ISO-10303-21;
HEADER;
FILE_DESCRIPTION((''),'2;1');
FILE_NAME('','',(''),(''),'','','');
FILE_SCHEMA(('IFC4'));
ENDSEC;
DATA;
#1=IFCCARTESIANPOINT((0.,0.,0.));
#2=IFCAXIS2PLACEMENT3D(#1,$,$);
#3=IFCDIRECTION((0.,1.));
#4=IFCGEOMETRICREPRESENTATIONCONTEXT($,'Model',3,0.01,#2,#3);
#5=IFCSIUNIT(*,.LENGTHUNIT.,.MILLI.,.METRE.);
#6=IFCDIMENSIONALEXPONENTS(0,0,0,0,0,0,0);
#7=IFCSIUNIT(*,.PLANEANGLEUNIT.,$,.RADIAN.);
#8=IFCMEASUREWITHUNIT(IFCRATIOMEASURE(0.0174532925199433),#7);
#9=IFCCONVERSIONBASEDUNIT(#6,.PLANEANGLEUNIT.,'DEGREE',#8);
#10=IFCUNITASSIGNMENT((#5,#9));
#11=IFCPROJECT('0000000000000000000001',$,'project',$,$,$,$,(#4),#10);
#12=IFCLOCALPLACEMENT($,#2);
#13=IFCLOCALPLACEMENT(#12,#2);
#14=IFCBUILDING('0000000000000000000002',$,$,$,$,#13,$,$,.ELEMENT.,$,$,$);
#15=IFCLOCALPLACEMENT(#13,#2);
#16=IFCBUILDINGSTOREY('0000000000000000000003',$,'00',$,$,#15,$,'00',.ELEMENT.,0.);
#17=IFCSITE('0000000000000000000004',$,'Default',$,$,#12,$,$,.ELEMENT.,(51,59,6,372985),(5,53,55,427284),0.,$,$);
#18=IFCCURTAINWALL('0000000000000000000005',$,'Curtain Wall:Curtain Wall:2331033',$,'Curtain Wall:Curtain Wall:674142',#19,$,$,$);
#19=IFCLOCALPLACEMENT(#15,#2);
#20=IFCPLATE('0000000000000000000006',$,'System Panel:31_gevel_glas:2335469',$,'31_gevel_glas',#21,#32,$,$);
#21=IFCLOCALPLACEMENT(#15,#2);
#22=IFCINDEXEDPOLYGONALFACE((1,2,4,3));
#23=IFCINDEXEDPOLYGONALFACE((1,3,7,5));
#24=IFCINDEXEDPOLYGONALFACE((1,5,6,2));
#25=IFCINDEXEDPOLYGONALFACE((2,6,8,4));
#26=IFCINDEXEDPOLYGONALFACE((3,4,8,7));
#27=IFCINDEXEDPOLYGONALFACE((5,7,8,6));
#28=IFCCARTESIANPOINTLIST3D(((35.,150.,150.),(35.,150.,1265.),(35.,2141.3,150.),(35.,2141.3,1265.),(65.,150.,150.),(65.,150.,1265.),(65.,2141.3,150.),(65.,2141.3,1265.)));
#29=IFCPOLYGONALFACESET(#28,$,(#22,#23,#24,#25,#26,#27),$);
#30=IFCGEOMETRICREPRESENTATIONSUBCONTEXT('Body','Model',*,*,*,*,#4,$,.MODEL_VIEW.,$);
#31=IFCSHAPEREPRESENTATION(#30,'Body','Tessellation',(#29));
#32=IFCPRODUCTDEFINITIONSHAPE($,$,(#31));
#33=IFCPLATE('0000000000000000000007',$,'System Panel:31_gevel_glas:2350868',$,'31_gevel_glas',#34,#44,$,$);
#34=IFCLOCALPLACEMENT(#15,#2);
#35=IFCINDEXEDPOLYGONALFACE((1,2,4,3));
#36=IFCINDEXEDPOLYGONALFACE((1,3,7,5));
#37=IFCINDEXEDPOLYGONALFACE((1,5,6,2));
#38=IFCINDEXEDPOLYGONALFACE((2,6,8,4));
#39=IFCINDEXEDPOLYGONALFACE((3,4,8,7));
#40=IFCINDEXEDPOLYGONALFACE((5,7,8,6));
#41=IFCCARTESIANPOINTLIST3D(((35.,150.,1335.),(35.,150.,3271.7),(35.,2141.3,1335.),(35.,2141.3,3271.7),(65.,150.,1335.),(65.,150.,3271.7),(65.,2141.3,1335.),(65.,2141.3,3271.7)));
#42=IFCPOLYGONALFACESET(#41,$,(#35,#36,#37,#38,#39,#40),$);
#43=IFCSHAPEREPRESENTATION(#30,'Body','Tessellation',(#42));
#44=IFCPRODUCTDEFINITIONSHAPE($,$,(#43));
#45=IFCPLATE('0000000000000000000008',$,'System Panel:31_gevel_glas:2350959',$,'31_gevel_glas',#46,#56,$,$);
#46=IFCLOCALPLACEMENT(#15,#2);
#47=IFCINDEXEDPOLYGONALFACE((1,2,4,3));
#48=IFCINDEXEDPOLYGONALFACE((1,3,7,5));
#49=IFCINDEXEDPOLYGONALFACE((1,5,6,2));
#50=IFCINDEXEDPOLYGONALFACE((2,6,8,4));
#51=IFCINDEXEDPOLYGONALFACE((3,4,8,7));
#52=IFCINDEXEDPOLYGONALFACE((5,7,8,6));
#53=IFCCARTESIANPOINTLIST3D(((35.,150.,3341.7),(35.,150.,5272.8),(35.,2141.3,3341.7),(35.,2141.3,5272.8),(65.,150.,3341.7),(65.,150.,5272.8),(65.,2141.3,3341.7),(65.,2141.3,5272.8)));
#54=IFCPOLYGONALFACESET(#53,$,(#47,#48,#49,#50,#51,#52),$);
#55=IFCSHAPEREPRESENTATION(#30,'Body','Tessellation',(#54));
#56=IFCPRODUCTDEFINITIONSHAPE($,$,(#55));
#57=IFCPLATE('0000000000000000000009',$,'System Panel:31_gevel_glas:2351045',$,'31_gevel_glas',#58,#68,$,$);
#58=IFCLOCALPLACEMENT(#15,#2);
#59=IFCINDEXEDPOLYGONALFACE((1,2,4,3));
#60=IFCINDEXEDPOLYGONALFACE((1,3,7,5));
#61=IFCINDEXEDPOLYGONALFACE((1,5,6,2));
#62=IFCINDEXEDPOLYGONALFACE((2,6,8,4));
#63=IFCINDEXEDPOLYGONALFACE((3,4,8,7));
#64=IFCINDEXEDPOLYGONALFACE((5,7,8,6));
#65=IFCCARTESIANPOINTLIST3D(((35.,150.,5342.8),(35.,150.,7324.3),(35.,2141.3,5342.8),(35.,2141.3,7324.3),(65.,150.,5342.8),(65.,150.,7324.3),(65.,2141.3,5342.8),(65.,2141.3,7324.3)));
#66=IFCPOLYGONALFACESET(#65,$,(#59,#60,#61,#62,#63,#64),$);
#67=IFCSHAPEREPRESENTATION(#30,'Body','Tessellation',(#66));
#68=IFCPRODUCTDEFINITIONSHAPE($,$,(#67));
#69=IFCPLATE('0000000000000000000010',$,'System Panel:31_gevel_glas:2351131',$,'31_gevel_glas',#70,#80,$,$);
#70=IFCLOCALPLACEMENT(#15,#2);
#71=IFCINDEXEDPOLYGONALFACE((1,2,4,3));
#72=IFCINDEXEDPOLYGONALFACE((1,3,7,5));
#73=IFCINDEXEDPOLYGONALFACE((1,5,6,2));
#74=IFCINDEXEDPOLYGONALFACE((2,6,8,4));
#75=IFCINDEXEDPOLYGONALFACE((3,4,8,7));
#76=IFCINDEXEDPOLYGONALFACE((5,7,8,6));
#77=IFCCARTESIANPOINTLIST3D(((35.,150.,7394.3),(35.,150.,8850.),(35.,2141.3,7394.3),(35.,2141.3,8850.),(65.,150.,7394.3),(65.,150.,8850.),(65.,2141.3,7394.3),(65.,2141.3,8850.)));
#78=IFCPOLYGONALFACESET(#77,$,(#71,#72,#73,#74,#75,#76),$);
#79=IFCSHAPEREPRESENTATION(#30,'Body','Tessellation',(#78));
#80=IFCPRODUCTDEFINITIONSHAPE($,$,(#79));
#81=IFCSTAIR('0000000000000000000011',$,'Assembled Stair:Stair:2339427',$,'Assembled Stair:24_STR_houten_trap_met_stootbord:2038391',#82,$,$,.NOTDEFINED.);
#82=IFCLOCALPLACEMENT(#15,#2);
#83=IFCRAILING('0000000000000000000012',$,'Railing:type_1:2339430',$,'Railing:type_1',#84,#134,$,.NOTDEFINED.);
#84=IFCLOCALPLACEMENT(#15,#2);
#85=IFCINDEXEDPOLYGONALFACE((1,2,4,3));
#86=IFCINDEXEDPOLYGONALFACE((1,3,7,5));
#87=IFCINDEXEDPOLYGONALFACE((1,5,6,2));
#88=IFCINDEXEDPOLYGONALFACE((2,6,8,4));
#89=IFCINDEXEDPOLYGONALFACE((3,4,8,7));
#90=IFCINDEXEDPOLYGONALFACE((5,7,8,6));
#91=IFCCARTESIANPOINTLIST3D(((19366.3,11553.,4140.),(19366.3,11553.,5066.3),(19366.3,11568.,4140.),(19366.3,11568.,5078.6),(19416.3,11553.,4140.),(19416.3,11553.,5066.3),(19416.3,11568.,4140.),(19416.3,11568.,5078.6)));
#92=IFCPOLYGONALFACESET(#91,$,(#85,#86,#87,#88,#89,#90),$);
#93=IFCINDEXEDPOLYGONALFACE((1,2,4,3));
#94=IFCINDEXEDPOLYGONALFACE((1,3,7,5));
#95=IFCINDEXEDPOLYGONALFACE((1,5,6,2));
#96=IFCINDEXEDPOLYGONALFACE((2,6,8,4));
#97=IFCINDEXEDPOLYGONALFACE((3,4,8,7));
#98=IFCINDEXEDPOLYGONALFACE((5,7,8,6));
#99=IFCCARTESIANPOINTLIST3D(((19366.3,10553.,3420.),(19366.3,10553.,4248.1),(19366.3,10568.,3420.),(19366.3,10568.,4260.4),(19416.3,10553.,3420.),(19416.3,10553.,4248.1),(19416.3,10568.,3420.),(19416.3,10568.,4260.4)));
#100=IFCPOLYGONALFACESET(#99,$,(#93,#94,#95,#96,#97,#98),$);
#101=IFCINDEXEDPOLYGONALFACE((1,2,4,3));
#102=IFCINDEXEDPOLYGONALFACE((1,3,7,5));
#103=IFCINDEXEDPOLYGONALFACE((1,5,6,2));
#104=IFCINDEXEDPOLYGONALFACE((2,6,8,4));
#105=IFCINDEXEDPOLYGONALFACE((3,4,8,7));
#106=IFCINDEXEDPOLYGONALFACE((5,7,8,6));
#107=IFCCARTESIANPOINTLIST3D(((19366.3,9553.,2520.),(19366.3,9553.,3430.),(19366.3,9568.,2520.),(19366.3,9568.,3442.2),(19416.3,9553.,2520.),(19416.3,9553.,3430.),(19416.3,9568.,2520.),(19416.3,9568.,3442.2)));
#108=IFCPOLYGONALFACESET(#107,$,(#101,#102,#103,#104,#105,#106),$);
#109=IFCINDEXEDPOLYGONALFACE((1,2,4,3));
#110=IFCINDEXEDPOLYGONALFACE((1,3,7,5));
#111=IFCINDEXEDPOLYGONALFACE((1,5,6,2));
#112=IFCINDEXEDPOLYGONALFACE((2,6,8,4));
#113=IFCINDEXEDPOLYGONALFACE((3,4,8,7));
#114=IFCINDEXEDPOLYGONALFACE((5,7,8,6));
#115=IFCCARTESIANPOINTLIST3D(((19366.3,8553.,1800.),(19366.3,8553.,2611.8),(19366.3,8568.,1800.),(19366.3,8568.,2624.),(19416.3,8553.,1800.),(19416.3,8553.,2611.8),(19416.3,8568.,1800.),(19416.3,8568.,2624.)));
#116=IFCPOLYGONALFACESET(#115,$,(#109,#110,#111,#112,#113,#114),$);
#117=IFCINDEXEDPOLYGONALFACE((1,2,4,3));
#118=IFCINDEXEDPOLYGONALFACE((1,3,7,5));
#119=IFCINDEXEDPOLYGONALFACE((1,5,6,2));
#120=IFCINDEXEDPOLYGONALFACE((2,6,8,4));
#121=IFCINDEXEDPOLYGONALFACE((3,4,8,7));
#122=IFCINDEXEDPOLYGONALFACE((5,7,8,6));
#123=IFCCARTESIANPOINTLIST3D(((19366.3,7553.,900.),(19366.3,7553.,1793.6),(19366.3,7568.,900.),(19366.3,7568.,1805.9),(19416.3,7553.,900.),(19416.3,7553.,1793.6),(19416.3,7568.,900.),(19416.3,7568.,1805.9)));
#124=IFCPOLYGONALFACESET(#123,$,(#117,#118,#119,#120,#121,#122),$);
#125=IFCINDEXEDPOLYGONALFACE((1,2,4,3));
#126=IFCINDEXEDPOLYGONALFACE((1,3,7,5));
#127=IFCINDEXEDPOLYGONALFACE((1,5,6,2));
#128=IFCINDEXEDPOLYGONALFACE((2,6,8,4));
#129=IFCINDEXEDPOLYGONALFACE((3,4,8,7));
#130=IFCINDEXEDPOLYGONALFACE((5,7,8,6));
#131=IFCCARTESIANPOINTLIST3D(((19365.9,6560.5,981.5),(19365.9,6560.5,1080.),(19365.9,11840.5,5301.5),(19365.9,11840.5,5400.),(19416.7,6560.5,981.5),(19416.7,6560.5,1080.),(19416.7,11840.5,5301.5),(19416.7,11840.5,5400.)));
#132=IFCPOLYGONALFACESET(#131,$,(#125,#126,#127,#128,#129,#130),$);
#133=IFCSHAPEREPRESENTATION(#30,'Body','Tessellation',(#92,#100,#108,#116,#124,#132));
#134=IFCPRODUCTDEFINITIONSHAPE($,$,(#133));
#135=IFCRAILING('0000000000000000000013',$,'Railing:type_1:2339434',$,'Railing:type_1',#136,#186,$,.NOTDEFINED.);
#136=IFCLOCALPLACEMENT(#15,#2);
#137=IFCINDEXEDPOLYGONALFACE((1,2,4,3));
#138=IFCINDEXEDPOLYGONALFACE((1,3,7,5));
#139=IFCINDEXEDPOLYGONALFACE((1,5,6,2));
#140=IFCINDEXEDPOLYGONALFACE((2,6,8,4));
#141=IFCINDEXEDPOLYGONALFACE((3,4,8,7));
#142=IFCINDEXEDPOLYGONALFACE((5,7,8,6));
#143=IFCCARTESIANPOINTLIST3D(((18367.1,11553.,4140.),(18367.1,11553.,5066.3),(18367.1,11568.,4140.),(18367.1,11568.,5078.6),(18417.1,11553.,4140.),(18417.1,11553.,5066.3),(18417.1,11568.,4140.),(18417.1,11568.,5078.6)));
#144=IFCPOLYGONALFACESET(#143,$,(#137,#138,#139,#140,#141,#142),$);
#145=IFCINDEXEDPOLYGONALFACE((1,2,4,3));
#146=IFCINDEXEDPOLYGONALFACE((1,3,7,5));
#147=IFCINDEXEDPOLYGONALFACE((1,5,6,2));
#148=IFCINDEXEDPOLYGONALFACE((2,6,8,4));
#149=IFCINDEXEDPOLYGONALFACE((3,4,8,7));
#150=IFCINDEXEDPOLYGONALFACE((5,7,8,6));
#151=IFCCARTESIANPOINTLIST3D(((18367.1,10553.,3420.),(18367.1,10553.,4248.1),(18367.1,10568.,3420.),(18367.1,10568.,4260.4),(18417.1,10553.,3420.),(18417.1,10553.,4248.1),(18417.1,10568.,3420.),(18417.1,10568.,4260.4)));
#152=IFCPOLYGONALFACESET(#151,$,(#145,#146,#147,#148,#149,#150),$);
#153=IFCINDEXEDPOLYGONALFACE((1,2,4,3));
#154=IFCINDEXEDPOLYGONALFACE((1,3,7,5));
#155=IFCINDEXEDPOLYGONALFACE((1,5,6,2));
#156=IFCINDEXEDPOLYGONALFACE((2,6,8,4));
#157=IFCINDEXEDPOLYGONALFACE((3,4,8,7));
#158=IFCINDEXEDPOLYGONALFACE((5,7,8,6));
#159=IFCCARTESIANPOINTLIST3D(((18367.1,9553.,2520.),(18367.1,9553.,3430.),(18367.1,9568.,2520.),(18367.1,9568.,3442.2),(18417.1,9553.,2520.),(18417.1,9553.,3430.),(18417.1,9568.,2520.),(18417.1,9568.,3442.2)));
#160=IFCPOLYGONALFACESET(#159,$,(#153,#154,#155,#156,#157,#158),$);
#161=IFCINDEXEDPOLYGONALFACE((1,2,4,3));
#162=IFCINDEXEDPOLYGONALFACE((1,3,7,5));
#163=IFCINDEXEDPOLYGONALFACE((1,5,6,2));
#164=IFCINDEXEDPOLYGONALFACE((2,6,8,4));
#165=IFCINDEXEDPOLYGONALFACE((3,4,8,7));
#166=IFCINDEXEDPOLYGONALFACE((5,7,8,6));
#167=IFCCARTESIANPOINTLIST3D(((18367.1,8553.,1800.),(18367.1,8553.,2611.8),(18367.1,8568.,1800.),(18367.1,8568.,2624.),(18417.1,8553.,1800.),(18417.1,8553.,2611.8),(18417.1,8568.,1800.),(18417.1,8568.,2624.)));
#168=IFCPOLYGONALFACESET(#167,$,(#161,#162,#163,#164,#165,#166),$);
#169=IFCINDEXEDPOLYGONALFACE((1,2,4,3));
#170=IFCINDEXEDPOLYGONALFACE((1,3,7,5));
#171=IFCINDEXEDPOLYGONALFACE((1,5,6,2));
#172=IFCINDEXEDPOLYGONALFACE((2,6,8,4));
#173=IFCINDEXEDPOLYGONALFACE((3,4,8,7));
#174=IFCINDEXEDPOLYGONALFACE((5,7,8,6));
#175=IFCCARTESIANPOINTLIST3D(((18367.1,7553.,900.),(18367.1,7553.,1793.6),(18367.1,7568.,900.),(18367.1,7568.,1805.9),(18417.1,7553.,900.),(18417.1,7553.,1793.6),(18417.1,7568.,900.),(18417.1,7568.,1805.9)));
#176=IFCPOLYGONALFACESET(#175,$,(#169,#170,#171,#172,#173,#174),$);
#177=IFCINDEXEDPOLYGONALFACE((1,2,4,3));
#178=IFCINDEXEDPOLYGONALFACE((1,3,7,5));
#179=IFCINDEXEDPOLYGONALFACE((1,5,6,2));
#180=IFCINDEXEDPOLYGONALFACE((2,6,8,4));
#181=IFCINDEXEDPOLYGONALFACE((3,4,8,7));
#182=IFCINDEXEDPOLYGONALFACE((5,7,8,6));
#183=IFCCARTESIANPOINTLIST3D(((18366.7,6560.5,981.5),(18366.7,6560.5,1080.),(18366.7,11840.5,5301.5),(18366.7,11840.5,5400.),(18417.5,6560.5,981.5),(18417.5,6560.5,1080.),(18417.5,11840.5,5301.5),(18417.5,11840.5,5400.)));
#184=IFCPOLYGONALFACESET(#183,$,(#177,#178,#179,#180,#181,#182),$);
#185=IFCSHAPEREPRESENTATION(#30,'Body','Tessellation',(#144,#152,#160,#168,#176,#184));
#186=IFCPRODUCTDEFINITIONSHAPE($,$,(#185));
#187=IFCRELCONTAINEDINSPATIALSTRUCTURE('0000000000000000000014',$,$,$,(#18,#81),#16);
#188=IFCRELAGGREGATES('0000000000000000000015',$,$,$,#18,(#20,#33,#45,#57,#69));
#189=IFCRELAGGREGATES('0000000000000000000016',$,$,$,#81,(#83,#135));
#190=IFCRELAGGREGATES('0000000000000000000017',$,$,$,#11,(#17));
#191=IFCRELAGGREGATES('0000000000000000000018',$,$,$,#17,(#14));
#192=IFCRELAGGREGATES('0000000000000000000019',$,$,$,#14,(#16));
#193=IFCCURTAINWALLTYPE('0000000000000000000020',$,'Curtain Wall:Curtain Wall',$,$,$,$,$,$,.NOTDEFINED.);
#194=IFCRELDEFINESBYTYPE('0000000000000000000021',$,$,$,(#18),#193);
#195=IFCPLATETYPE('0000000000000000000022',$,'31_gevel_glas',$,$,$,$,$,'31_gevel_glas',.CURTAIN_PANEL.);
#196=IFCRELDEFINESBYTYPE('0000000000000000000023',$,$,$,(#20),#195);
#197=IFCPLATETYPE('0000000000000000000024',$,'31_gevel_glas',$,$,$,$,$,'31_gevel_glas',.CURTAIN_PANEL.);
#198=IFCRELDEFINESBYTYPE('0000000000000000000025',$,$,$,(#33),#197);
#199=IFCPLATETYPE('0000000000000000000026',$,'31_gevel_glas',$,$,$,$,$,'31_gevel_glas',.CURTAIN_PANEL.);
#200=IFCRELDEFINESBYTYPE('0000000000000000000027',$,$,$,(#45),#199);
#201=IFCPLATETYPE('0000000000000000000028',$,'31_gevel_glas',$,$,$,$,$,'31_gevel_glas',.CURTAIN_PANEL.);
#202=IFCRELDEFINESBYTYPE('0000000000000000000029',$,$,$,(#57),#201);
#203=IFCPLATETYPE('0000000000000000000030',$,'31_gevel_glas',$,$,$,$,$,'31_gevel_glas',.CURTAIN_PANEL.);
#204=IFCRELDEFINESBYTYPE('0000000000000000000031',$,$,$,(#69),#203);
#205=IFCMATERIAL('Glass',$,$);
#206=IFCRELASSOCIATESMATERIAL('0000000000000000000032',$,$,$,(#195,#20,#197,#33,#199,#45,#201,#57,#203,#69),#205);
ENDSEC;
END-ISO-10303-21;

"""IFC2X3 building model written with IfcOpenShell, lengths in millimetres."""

from ifc_helpers import new_model, entity, si_unit, converted_unit, direction, frame, origin, origin_2d_with_axis, place, context, subcontext, project, spatial, polyline, rectangle, outline, extrude, source, transform, mapped, material, type_object, type_shapes, element, aggregate, save


model = new_model("IFC2X3")

# Units and contexts
model_context = context("Model", 3, precision=0.01, world=origin(), true_north=direction((0.0, 1.0)))
body_context = subcontext(model_context, "Body", "Model", "MODEL_VIEW")
ifc_project = project(units=[si_unit("LENGTHUNIT", "METRE", prefix="MILLI"), converted_unit("PLANEANGLEUNIT", "DEGREE", entity("IfcRatioMeasure", 0.0174532925199433), si_unit("PLANEANGLEUNIT", "RADIAN"), dimensions=[0, 0, 0, 0, 0, 0, 0])], contexts=[model_context])

# Site, building, storey
site_placement = place(None, origin())
site = spatial("IfcSite", under=ifc_project, at=site_placement, Name="Default", CompositionType="ELEMENT", RefLatitude=(51, 59, 6, 372985), RefLongitude=(5, 53, 55, 427284), RefElevation=0.0)
building_placement = place(site_placement, origin())
building = spatial("IfcBuilding", under=site, at=building_placement, CompositionType="ELEMENT")
storey_placement = place(building_placement, origin())
storey = spatial("IfcBuildingStorey", under=building, at=storey_placement, Name="00", LongName="00", CompositionType="ELEMENT", Elevation=0.0)

# Curtain wall, plates
curtain_wall_type = type_object("IfcCurtainWallType", Name="Curtain Wall:Curtain Wall", PredefinedType="NOTDEFINED")
curtain_wall_placement = place(storey_placement, origin())
curtain_wall = element("IfcCurtainWall", 1, at=curtain_wall_placement, inside=storey, type_object=curtain_wall_type, Name="Curtain Wall:Curtain Wall:2331033", ObjectType="Curtain Wall:Curtain Wall:674142")
ifc_material = material(Name="Glass")
plate_type_1 = type_object("IfcPlateType", Name="31_gevel_glas", ElementType="31_gevel_glas", PredefinedType="CURTAIN_PANEL", material=ifc_material)
shared_shape_1 = source(origin(), body_context, "Body", "SweptSolid", [
    extrude(rectangle(XDim=30.0, YDim=1991.3, at=origin_2d_with_axis()), frame((0.0, 50.0, 0.0), z_axis=(0.0, 0.0, 1.0), x_axis=(0.0, 1.0, 0.0)), (0.0, 0.0, 1.0), 1115.0),
])
type_shapes(plate_type_1, [shared_shape_1])
plate_1_placement = place(curtain_wall_placement, frame((0.0, 1145.7, 150.0), z_axis=(0.0, 0.0, 1.0), x_axis=(0.0, -1.0, 0.0)))
plate_1 = element("IfcPlate", 2, at=plate_1_placement, type_object=plate_type_1, material=ifc_material, Name="System Panel:31_gevel_glas:2335469", ObjectType="31_gevel_glas", context=body_context, shape_type="MappedRepresentation", body=[
    mapped(shared_shape_1, transform((0.0, 0.0, 0.0), scale=1.0)),
])
plate_type_2 = type_object("IfcPlateType", Name="31_gevel_glas", ElementType="31_gevel_glas", PredefinedType="CURTAIN_PANEL", material=ifc_material)
shared_shape_2 = source(origin(), body_context, "Body", "SweptSolid", [
    extrude(rectangle(XDim=30.0, YDim=1991.3, at=origin_2d_with_axis()), frame((0.0, 50.0, 0.0), z_axis=(0.0, 0.0, 1.0), x_axis=(0.0, 1.0, 0.0)), (0.0, 0.0, 1.0), 1936.7),
])
type_shapes(plate_type_2, [shared_shape_2])
plate_2_placement = place(curtain_wall_placement, frame((0.0, 1145.7, 1335.0), z_axis=(0.0, 0.0, 1.0), x_axis=(0.0, -1.0, 0.0)))
plate_2 = element("IfcPlate", 3, at=plate_2_placement, type_object=plate_type_2, material=ifc_material, Name="System Panel:31_gevel_glas:2350868", ObjectType="31_gevel_glas", context=body_context, shape_type="MappedRepresentation", body=[
    mapped(shared_shape_2, transform((0.0, 0.0, 0.0), scale=1.0)),
])
plate_type_3 = type_object("IfcPlateType", Name="31_gevel_glas", ElementType="31_gevel_glas", PredefinedType="CURTAIN_PANEL", material=ifc_material)
shared_shape_3 = source(origin(), body_context, "Body", "SweptSolid", [
    extrude(rectangle(XDim=30.0, YDim=1991.3, at=origin_2d_with_axis()), frame((0.0, 50.0, 0.0), z_axis=(0.0, 0.0, 1.0), x_axis=(0.0, 1.0, 0.0)), (0.0, 0.0, 1.0), 1931.1),
])
type_shapes(plate_type_3, [shared_shape_3])
plate_3_placement = place(curtain_wall_placement, frame((0.0, 1145.7, 3341.7), z_axis=(0.0, 0.0, 1.0), x_axis=(0.0, -1.0, 0.0)))
plate_3 = element("IfcPlate", 4, at=plate_3_placement, type_object=plate_type_3, material=ifc_material, Name="System Panel:31_gevel_glas:2350959", ObjectType="31_gevel_glas", context=body_context, shape_type="MappedRepresentation", body=[
    mapped(shared_shape_3, transform((0.0, 0.0, 0.0), scale=1.0)),
])
plate_type_4 = type_object("IfcPlateType", Name="31_gevel_glas", ElementType="31_gevel_glas", PredefinedType="CURTAIN_PANEL", material=ifc_material)
shared_shape_4 = source(origin(), body_context, "Body", "SweptSolid", [
    extrude(rectangle(XDim=30.0, YDim=1991.3, at=origin_2d_with_axis()), frame((0.0, 50.0, 0.0), z_axis=(0.0, 0.0, 1.0), x_axis=(0.0, 1.0, 0.0)), (0.0, 0.0, 1.0), 1981.5),
])
type_shapes(plate_type_4, [shared_shape_4])
plate_4_placement = place(curtain_wall_placement, frame((0.0, 1145.7, 5342.8), z_axis=(0.0, 0.0, 1.0), x_axis=(0.0, -1.0, 0.0)))
plate_4 = element("IfcPlate", 5, at=plate_4_placement, type_object=plate_type_4, material=ifc_material, Name="System Panel:31_gevel_glas:2351045", ObjectType="31_gevel_glas", context=body_context, shape_type="MappedRepresentation", body=[
    mapped(shared_shape_4, transform((0.0, 0.0, 0.0), scale=1.0)),
])
plate_type_5 = type_object("IfcPlateType", Name="31_gevel_glas", ElementType="31_gevel_glas", PredefinedType="CURTAIN_PANEL", material=ifc_material)
shared_shape_5 = source(origin(), body_context, "Body", "SweptSolid", [
    extrude(rectangle(XDim=30.0, YDim=1991.3, at=origin_2d_with_axis()), frame((0.0, 50.0, 0.0), z_axis=(0.0, 0.0, 1.0), x_axis=(0.0, 1.0, 0.0)), (0.0, 0.0, 1.0), 1455.7),
])
type_shapes(plate_type_5, [shared_shape_5])
plate_5_placement = place(curtain_wall_placement, frame((0.0, 1145.7, 7394.3), z_axis=(0.0, 0.0, 1.0), x_axis=(0.0, -1.0, 0.0)))
plate_5 = element("IfcPlate", 6, at=plate_5_placement, type_object=plate_type_5, material=ifc_material, Name="System Panel:31_gevel_glas:2351131", ObjectType="31_gevel_glas", context=body_context, shape_type="MappedRepresentation", body=[
    mapped(shared_shape_5, transform((0.0, 0.0, 0.0), scale=1.0)),
])
aggregate(curtain_wall, [plate_1, plate_2, plate_3, plate_4, plate_5])

# Stair, railings
stair_1_placement = place(storey_placement, origin())
stair_1 = element("IfcStair", 7, at=stair_1_placement, inside=storey, Name="Assembled Stair:Stair:2339427", ObjectType="Assembled Stair:24_STR_houten_trap_met_stootbord:2038391", ShapeType="NOTDEFINED")
railing_1_placement = place(stair_1_placement, origin())
railing_1 = element("IfcRailing", 8, at=railing_1_placement, Name="Railing:type_1:2339430", ObjectType="Railing:type_1", PredefinedType="NOTDEFINED", context=body_context, shape_type="SweptSolid", body=[
    extrude(outline(polyline([(-7.5, -466.2), (7.5, -466.2), (7.5, 472.4), (-7.5, 460.1), (-7.5, -466.2)])), frame((19366.3, 11560.5, 4606.2), z_axis=(1.0, 0.0, 0.0), x_axis=(0.0, 1.0, 0.0)), (0.0, 0.0, 1.0), 50.0),
    extrude(outline(polyline([(-7.5, -417.1), (7.5, -417.1), (7.5, 423.3), (-7.5, 411.0), (-7.5, -417.1)])), frame((19366.3, 10560.5, 3837.1), z_axis=(1.0, 0.0, 0.0), x_axis=(0.0, 1.0, 0.0)), (0.0, 0.0, 1.0), 50.0),
    extrude(outline(polyline([(-7.5, -458.0), (7.5, -458.0), (7.5, 464.2), (-7.5, 451.9), (-7.5, -458.0)])), frame((19366.3, 9560.5, 2978.0), z_axis=(1.0, 0.0, 0.0), x_axis=(0.0, 1.0, 0.0)), (0.0, 0.0, 1.0), 50.0),
    extrude(outline(polyline([(-7.5, -409.0), (7.5, -409.0), (7.5, 415.1), (-7.5, 402.8), (-7.5, -409.0)])), frame((19366.3, 8560.5, 2209.0), z_axis=(1.0, 0.0, 0.0), x_axis=(0.0, 1.0, 0.0)), (0.0, 0.0, 1.0), 50.0),
    extrude(outline(polyline([(-7.5, -449.9), (7.5, -449.9), (7.5, 456.0), (-7.5, 443.7), (-7.5, -449.9)])), frame((19366.3, 7560.5, 1349.9), z_axis=(1.0, 0.0, 0.0), x_axis=(0.0, 1.0, 0.0)), (0.0, 0.0, 1.0), 50.0),
    extrude(outline(polyline([(-3442.2, -38.1), (3379.9, -38.1), (3442.2, 38.1), (-3379.9, 38.1), (-3442.2, -38.1)])), frame((19365.9, 9200.5, 3190.8), z_axis=(1.0, 0.0, 0.0), x_axis=(0.0, 0.773957, 0.633238)), (0.0, 0.0, 1.0), 50.8),
])
railing_2_placement = place(stair_1_placement, origin())
railing_2 = element("IfcRailing", 9, at=railing_2_placement, Name="Railing:type_1:2339434", ObjectType="Railing:type_1", PredefinedType="NOTDEFINED", context=body_context, shape_type="SweptSolid", body=[
    extrude(outline(polyline([(-460.1, -7.5), (466.2, -7.5), (466.2, 7.5), (-472.4, 7.5), (-460.1, -7.5)])), frame((18367.1, 11560.5, 4606.2), z_axis=(1.0, 0.0, 0.0), x_axis=(0.0, 0.0, -1.0)), (0.0, 0.0, 1.0), 50.0),
    extrude(outline(polyline([(-411.0, -7.5), (417.1, -7.5), (417.1, 7.5), (-423.3, 7.5), (-411.0, -7.5)])), frame((18367.1, 10560.5, 3837.1), z_axis=(1.0, 0.0, 0.0), x_axis=(0.0, 0.0, -1.0)), (0.0, 0.0, 1.0), 50.0),
    extrude(outline(polyline([(-451.9, -7.5), (458.0, -7.5), (458.0, 7.5), (-464.2, 7.5), (-451.9, -7.5)])), frame((18367.1, 9560.5, 2978.0), z_axis=(1.0, 0.0, 0.0), x_axis=(0.0, 0.0, -1.0)), (0.0, 0.0, 1.0), 50.0),
    extrude(outline(polyline([(-402.8, -7.5), (409.0, -7.5), (409.0, 7.5), (-415.1, 7.5), (-402.8, -7.5)])), frame((18367.1, 8560.5, 2209.0), z_axis=(1.0, 0.0, 0.0), x_axis=(0.0, 0.0, -1.0)), (0.0, 0.0, 1.0), 50.0),
    extrude(outline(polyline([(-443.7, -7.5), (449.9, -7.5), (449.9, 7.5), (-456.0, 7.5), (-443.7, -7.5)])), frame((18367.1, 7560.5, 1349.9), z_axis=(1.0, 0.0, 0.0), x_axis=(0.0, 0.0, -1.0)), (0.0, 0.0, 1.0), 50.0),
    extrude(outline(polyline([(-3442.2, -38.1), (3379.9, -38.1), (3442.2, 38.1), (-3379.9, 38.1), (-3442.2, -38.1)])), frame((18366.7, 9200.5, 3190.8), z_axis=(1.0, 0.0, 0.0), x_axis=(0.0, 0.773957, 0.633238)), (0.0, 0.0, 1.0), 50.8),
])
aggregate(stair_1, [railing_1, railing_2])

save(model, "model.ifc")
